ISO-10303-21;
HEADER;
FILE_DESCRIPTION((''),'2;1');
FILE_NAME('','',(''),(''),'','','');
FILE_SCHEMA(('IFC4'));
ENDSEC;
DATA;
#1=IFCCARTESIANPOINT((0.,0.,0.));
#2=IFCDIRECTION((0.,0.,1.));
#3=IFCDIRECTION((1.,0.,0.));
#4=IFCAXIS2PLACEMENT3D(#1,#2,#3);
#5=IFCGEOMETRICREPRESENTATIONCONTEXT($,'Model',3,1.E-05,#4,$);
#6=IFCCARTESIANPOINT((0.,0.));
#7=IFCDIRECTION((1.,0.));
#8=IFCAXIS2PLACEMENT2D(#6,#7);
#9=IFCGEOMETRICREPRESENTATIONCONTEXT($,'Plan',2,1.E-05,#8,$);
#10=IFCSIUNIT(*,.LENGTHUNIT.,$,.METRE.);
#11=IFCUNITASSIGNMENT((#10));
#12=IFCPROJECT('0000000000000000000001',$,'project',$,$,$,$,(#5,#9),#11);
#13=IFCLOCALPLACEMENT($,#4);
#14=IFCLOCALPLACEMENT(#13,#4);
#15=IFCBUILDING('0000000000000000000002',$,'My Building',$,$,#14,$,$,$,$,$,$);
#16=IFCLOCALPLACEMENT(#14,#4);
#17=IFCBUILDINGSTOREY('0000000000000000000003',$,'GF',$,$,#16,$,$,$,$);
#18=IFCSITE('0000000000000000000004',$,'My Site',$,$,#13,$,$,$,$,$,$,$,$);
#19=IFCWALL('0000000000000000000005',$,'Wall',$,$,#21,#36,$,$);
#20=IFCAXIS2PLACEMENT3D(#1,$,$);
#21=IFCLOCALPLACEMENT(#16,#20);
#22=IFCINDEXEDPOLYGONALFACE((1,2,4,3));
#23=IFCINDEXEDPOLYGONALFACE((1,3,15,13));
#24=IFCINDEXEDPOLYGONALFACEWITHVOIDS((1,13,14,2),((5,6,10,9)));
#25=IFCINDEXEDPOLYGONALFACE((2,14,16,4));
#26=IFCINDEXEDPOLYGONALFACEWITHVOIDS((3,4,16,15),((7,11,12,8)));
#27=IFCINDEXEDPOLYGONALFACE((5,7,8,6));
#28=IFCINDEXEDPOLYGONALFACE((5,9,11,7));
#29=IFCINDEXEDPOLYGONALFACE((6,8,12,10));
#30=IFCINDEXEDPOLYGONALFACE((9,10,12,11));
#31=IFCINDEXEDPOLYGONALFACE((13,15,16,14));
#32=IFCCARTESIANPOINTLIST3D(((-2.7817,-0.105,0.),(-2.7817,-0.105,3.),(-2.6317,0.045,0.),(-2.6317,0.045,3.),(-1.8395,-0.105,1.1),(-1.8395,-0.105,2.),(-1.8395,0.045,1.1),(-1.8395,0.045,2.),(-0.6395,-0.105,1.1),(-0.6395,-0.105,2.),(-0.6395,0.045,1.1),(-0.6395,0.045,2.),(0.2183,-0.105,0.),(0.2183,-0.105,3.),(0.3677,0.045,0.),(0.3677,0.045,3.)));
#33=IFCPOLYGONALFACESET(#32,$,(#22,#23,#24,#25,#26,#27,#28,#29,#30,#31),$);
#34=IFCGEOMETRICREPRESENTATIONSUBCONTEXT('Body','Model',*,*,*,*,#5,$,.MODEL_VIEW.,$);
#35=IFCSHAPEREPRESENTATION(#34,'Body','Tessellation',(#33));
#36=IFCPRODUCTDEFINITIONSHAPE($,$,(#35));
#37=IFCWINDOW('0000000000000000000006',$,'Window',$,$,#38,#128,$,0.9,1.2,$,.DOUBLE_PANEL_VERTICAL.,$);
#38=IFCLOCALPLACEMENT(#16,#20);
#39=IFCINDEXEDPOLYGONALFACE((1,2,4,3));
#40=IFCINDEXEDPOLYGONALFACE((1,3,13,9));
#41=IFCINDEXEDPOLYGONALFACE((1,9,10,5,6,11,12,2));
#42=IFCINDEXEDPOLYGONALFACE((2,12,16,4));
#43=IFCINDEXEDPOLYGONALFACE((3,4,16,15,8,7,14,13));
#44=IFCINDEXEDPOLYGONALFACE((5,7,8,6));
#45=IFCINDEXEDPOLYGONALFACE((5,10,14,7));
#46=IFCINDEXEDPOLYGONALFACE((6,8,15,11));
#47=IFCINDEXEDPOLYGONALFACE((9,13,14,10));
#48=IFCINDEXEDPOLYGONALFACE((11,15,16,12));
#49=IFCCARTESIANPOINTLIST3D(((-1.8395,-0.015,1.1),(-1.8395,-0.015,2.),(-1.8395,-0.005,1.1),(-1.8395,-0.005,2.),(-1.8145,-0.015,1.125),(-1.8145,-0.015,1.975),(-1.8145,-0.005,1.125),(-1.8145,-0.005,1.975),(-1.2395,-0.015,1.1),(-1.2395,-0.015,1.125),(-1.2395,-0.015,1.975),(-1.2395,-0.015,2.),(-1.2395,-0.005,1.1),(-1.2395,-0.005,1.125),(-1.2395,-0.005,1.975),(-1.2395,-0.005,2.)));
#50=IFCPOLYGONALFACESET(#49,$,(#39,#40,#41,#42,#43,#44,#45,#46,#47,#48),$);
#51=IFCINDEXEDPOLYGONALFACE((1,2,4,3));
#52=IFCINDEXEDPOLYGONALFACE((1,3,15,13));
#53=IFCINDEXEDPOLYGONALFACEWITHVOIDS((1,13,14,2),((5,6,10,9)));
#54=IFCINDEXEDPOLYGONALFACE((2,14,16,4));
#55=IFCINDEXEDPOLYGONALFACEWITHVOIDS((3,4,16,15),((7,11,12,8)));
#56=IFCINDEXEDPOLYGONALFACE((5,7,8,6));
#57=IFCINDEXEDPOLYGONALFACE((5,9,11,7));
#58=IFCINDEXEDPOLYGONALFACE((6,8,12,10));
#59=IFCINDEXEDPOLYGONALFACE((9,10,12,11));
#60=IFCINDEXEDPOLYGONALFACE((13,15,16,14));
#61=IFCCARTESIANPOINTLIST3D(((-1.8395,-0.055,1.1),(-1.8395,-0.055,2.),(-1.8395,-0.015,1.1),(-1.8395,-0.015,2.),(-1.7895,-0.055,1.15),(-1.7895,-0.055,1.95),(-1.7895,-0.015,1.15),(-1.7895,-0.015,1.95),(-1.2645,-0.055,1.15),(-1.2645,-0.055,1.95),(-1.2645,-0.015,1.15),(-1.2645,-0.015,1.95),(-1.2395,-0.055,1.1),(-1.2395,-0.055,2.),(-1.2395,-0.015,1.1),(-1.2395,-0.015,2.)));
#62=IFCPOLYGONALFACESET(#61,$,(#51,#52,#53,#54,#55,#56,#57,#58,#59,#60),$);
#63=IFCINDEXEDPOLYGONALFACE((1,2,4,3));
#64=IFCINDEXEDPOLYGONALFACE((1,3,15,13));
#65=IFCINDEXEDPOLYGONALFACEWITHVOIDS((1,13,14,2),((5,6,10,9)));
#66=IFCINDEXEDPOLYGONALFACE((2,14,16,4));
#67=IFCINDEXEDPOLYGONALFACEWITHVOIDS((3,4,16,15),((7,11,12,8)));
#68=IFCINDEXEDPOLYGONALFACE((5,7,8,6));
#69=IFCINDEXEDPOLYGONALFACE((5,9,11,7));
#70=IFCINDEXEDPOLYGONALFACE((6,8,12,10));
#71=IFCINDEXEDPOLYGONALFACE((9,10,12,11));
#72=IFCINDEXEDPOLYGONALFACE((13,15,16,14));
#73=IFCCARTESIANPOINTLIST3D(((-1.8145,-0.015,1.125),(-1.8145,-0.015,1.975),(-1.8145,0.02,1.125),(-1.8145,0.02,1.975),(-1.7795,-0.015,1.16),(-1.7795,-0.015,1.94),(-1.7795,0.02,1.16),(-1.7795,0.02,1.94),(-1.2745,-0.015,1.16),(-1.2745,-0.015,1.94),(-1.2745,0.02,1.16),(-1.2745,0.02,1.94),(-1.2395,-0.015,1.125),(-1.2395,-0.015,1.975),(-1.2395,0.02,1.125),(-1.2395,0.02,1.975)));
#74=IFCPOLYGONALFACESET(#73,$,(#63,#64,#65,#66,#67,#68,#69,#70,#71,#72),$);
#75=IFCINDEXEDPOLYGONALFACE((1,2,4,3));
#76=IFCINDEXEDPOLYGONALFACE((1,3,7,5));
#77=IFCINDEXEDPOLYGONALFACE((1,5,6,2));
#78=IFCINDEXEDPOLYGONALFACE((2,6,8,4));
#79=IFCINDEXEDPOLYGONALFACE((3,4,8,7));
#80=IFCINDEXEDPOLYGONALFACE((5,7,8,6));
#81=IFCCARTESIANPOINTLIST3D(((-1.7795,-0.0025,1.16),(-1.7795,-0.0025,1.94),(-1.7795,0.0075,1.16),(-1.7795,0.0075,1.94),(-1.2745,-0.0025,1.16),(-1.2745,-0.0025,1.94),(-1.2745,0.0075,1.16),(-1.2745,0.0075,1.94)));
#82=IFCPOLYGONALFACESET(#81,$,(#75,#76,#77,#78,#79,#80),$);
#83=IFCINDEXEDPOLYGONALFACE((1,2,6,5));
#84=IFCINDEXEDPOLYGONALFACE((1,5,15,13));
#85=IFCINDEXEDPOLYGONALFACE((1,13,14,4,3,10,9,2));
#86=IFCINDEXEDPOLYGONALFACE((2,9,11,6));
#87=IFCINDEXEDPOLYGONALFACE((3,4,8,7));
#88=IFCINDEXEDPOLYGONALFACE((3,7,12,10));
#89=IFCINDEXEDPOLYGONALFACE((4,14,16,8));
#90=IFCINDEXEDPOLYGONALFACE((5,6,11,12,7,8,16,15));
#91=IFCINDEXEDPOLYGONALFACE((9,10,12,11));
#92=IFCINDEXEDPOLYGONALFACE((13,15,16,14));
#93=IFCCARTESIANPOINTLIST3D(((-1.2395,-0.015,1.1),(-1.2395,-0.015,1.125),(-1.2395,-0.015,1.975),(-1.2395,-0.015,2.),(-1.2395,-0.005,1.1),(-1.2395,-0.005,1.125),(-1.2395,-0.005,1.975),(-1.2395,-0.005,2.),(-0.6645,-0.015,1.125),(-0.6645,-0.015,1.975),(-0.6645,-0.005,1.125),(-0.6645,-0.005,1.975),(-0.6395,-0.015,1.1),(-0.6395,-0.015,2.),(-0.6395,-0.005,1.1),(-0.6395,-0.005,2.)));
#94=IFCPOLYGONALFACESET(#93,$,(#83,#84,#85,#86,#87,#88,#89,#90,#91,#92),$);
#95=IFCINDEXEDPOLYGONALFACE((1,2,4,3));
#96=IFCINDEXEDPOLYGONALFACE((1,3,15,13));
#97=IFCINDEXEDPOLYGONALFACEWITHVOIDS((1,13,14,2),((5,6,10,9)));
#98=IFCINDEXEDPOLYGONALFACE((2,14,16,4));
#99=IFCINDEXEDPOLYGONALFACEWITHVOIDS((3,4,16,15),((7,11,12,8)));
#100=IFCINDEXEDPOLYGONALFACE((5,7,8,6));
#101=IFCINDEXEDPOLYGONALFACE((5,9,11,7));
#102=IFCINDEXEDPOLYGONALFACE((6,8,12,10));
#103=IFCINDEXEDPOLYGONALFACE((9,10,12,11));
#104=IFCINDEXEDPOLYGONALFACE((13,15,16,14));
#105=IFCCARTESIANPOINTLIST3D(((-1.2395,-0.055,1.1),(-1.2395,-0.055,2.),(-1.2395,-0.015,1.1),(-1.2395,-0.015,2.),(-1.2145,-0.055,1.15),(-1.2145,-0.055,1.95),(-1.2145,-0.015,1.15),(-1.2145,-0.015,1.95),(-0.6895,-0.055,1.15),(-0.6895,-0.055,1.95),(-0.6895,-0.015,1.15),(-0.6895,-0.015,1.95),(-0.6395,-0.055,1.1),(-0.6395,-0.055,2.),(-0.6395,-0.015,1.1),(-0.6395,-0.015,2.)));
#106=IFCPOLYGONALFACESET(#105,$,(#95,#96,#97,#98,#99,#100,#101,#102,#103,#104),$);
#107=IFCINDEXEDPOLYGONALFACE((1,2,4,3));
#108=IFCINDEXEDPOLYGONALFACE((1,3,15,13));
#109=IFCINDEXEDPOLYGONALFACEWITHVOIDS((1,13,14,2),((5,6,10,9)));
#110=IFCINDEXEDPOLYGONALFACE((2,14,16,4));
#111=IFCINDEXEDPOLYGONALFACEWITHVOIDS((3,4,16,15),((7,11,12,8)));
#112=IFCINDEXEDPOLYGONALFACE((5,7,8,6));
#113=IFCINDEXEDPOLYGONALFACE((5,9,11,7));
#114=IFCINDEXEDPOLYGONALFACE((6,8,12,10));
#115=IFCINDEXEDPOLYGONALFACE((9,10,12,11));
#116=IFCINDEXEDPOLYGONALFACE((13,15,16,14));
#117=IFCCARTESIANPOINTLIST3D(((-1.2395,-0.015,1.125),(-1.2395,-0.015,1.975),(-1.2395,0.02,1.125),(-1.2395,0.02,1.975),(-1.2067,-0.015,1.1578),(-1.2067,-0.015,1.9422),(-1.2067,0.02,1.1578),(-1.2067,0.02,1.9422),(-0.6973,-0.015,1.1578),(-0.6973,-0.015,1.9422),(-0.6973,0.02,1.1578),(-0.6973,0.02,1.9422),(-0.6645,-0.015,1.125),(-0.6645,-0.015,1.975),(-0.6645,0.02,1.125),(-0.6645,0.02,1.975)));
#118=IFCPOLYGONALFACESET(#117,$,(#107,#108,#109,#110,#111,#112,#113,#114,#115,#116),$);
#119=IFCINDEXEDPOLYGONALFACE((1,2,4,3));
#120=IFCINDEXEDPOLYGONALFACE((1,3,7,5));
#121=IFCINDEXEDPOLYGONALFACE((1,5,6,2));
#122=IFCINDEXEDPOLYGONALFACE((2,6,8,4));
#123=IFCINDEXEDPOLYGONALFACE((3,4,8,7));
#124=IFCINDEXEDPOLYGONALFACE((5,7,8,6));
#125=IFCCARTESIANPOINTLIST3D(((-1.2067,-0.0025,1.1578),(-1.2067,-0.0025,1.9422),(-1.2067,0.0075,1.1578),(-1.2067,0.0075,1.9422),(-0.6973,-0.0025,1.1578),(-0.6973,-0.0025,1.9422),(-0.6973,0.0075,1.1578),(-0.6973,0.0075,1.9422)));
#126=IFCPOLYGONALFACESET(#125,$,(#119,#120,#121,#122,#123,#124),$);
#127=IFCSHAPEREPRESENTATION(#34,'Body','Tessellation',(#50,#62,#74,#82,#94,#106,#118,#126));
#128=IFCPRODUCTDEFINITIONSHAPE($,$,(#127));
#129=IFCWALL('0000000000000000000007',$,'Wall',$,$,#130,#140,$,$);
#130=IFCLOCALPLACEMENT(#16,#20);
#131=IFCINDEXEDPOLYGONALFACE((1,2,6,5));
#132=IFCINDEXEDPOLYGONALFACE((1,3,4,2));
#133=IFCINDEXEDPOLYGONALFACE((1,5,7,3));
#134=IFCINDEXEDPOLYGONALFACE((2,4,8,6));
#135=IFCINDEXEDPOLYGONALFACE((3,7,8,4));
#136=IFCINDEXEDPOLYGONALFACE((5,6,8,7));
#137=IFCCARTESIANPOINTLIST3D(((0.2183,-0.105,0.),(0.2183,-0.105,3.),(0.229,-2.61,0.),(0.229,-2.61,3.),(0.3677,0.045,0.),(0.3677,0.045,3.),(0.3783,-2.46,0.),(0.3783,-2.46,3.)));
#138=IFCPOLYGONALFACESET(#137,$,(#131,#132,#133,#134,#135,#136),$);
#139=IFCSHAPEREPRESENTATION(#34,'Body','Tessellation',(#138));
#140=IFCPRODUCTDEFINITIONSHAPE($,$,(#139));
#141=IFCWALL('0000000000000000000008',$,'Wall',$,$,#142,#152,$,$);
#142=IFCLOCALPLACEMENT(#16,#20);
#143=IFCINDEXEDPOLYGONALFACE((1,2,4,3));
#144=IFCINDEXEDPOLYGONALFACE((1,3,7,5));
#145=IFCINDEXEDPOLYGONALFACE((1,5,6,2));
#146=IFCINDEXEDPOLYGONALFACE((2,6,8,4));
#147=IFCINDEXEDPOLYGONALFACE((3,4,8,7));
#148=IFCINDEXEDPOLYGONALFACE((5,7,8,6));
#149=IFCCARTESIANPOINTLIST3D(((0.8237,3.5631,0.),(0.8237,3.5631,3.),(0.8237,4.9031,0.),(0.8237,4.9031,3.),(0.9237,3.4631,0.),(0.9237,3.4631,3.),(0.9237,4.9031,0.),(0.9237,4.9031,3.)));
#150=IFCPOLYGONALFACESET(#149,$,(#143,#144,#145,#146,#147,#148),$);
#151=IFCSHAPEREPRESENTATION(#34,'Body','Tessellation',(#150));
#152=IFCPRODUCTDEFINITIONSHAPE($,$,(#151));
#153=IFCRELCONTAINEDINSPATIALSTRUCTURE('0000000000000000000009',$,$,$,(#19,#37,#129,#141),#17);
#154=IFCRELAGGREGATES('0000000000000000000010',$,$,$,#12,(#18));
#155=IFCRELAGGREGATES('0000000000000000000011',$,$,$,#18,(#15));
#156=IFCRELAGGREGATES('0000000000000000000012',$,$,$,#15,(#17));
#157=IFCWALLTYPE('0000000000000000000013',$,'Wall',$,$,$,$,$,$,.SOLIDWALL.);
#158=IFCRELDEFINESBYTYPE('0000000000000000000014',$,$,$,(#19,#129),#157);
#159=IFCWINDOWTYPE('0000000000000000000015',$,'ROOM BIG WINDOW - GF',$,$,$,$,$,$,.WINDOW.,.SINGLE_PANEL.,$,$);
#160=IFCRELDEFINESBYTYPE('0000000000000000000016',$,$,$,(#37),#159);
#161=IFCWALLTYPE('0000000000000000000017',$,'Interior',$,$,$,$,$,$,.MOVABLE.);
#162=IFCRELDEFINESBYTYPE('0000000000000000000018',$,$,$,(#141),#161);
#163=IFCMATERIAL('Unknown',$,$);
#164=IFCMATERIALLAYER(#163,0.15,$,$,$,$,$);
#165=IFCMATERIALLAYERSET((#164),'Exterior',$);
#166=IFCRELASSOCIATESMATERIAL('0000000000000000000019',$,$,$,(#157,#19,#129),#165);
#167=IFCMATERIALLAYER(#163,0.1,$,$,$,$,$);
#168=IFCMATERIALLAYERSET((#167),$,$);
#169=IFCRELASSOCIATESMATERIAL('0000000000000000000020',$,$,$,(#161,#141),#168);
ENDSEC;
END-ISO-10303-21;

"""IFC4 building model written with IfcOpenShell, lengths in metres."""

from ifc_helpers import new_model, entity, si_unit, frame, origin_with_axes, origin_2d_with_axis, place, context, subcontext, project, spatial, line, indexed_curve, outline, extrude, shape, source, transform, mapped, material, layer, layer_set, layer_usage, type_object, type_shapes, element, fill, save


model = new_model("IFC4")

# Units and contexts
model_context = context("Model", 3, precision=1e-05, world=origin_with_axes())
plan_context = context("Plan", 2, precision=1e-05, world=origin_2d_with_axis())
body_context_1 = subcontext(model_context, "Body", "Model", "MODEL_VIEW")
body_context_2 = subcontext(plan_context, "Body", "Plan", "PLAN_VIEW")
ifc_project = project(units=[si_unit("LENGTHUNIT", "METRE")], contexts=[model_context, plan_context])

# Site, building, storey
site_placement = place(None, origin_with_axes())
site = spatial("IfcSite", under=ifc_project, at=site_placement, Name="My Site")
building_placement = place(site_placement, origin_with_axes())
building = spatial("IfcBuilding", under=site, at=building_placement, Name="My Building")
storey_placement = place(building_placement, origin_with_axes())
storey = spatial("IfcBuildingStorey", under=building, at=storey_placement, Name="GF")

# Shared definitions
ifc_material = material(Name="Unknown")

# Shared definitions
ifc_layer_1 = layer(ifc_material, 0.15)
ifc_layer_set_1 = layer_set([ifc_layer_1], Name="Exterior")
wall_type_1 = type_object("IfcWallType", Name="Wall", PredefinedType="SOLIDWALL", material=ifc_layer_set_1)

# Wall, opening, window
shared_shape_1 = source(origin_with_axes(), body_context_1, "Body", "SweptSolid", [
    extrude(outline(indexed_curve([(0.0, 0.0), (1.2, 0.0), (1.2, 0.9), (0.0, 0.9)], segments=[line(1, 2, 3, 4, 1)])), frame((0.0, -0.6, 0.0), z_axis=(0.0, -1.0, 0.0), x_axis=(1.0, 0.0, 0.0)), (0.0, 0.0, -1.0), 1.2),
])
window_type_1 = type_object("IfcWindowType", Name="ROOM BIG WINDOW - GF", PartitioningType="SINGLE_PANEL", PredefinedType="WINDOW")
shared_shape_2 = source(origin_with_axes(), body_context_1, "Body", "SweptSolid", [
    extrude(outline(indexed_curve([(0.6, 0.0), (0.0, 0.0), (0.0, 0.9), (0.6, 0.9), (0.6, 0.875), (0.025, 0.875), (0.025, 0.025), (0.6, 0.025)], segments=[line(1, 2, 3, 4, 5, 6, 7, 8, 1)])), frame((0.0, 0.09, 0.0), z_axis=(0.0, -1.0, 0.0), x_axis=(1.0, 0.0, 0.0)), (0.0, 0.0, -1.0), 0.01),
    extrude(outline(indexed_curve([(0.0, 0.0), (0.6, 0.0), (0.6, 0.9), (0.0, 0.9)], segments=[line(1, 2, 3, 4, 1)]), holes=[indexed_curve([(0.05, 0.05), (0.575, 0.05), (0.575, 0.85), (0.05, 0.85)], segments=[line(1, 2, 3, 4, 1)])]), frame((0.0, 0.05, 0.0), z_axis=(0.0, -1.0, 0.0), x_axis=(1.0, 0.0, 0.0)), (0.0, 0.0, -1.0), 0.04),
    extrude(outline(indexed_curve([(0.0, 0.0), (0.575, 0.0), (0.575, 0.85), (0.0, 0.85)], segments=[line(1, 2, 3, 4, 1)]), holes=[indexed_curve([(0.035, 0.035), (0.54, 0.035), (0.54, 0.815), (0.035, 0.815)], segments=[line(1, 2, 3, 4, 1)])]), frame((0.025, 0.09, 0.025), z_axis=(0.0, -1.0, 0.0), x_axis=(1.0, 0.0, 0.0)), (0.0, 0.0, -1.0), 0.035),
    extrude(outline(indexed_curve([(0.035, 0.035), (0.54, 0.035), (0.54, 0.815), (0.035, 0.815)], segments=[line(1, 2, 3, 4, 1)])), frame((0.025, 0.1025, 0.025), z_axis=(0.0, -1.0, 0.0), x_axis=(1.0, 0.0, 0.0)), (0.0, 0.0, -1.0), 0.01),
    extrude(outline(indexed_curve([(0.0, 0.9), (0.6, 0.9), (0.6, 0.0), (0.0, 0.0), (0.0, 0.025), (0.575, 0.025), (0.575, 0.875), (0.0, 0.875)], segments=[line(1, 2, 3, 4, 5, 6, 7, 8, 1)])), frame((0.6, 0.09, 0.0), z_axis=(0.0, -1.0, 0.0), x_axis=(1.0, 0.0, 0.0)), (0.0, 0.0, -1.0), 0.01),
    extrude(outline(indexed_curve([(0.0, 0.0), (0.6, 0.0), (0.6, 0.9), (0.0, 0.9)], segments=[line(1, 2, 3, 4, 1)]), holes=[indexed_curve([(0.025, 0.05), (0.55, 0.05), (0.55, 0.85), (0.025, 0.85)], segments=[line(1, 2, 3, 4, 1)])]), frame((0.6, 0.05, 0.0), z_axis=(0.0, -1.0, 0.0), x_axis=(1.0, 0.0, 0.0)), (0.0, 0.0, -1.0), 0.04),
    extrude(outline(indexed_curve([(0.0, 0.0), (0.575, 0.0), (0.575, 0.85), (0.0, 0.85)], segments=[line(1, 2, 3, 4, 1)]), holes=[indexed_curve([(0.0328, 0.0328), (0.5422, 0.0328), (0.5422, 0.8172), (0.0328, 0.8172)], segments=[line(1, 2, 3, 4, 1)])]), frame((0.6, 0.09, 0.025), z_axis=(0.0, -1.0, 0.0), x_axis=(1.0, 0.0, 0.0)), (0.0, 0.0, -1.0), 0.035),
    extrude(outline(indexed_curve([(0.0328, 0.0328), (0.5422, 0.0328), (0.5422, 0.8172), (0.0328, 0.8172)], segments=[line(1, 2, 3, 4, 1)])), frame((0.6, 0.1025, 0.025), z_axis=(0.0, -1.0, 0.0), x_axis=(1.0, 0.0, 0.0)), (0.0, 0.0, -1.0), 0.01),
])
shared_shape_3 = source(origin_with_axes(), body_context_2, "Body", "Curve2D", [
    entity("IfcIndexedPolyCurve", entity("IfcCartesianPointList2D", [[0.05, 0.05], [0.575, 0.05]])),
    entity("IfcIndexedPolyCurve", entity("IfcCartesianPointList2D", [[0.0, 0.1], [0.025, 0.1], [0.025, 0.09], [0.05, 0.09], [0.05, 0.05], [0.0, 0.05]]), [entity("IfcLineIndex", [1, 2, 3, 4, 5, 6, 1])]),
    entity("IfcIndexedPolyCurve", entity("IfcCartesianPointList2D", [[0.6, 0.1], [0.6, 0.1], [0.6, 0.09], [0.575, 0.09], [0.575, 0.05], [0.6, 0.05]])),
    entity("IfcIndexedPolyCurve", entity("IfcCartesianPointList2D", [[0.025, 0.09], [0.06, 0.09], [0.06, 0.125], [0.025, 0.125]]), [entity("IfcLineIndex", [1, 2, 3, 4, 1])]),
    entity("IfcIndexedPolyCurve", entity("IfcCartesianPointList2D", [[0.6, 0.09], [0.565, 0.09], [0.565, 0.125], [0.6, 0.125]]), [entity("IfcLineIndex", [1, 2, 3, 4, 1])]),
    entity("IfcIndexedPolyCurve", entity("IfcCartesianPointList2D", [[0.06, 0.09], [0.565, 0.09]])),
    entity("IfcIndexedPolyCurve", entity("IfcCartesianPointList2D", [[0.06, 0.125], [0.565, 0.125]])),
    entity("IfcIndexedPolyCurve", entity("IfcCartesianPointList2D", [[0.06, 0.1075], [0.565, 0.1075]])),
    entity("IfcIndexedPolyCurve", entity("IfcCartesianPointList2D", [[0.625, 0.05], [1.15, 0.05]])),
    entity("IfcIndexedPolyCurve", entity("IfcCartesianPointList2D", [[0.6, 0.1], [0.6, 0.1], [0.6, 0.09], [0.625, 0.09], [0.625, 0.05], [0.6, 0.05]])),
    entity("IfcIndexedPolyCurve", entity("IfcCartesianPointList2D", [[1.2, 0.1], [1.175, 0.1], [1.175, 0.09], [1.15, 0.09], [1.15, 0.05], [1.2, 0.05]]), [entity("IfcLineIndex", [1, 2, 3, 4, 5, 6, 1])]),
    entity("IfcIndexedPolyCurve", entity("IfcCartesianPointList2D", [[0.6, 0.09], [0.6328, 0.09], [0.6328, 0.125], [0.6, 0.125]]), [entity("IfcLineIndex", [1, 2, 3, 4, 1])]),
    entity("IfcIndexedPolyCurve", entity("IfcCartesianPointList2D", [[1.175, 0.09], [1.1422, 0.09], [1.1422, 0.125], [1.175, 0.125]]), [entity("IfcLineIndex", [1, 2, 3, 4, 1])]),
    entity("IfcIndexedPolyCurve", entity("IfcCartesianPointList2D", [[0.6328, 0.09], [1.1422, 0.09]])),
    entity("IfcIndexedPolyCurve", entity("IfcCartesianPointList2D", [[0.6328, 0.125], [1.1422, 0.125]])),
    entity("IfcIndexedPolyCurve", entity("IfcCartesianPointList2D", [[0.6328, 0.1075], [1.1422, 0.1075]])),
])
type_shapes(window_type_1, [shared_shape_2, shared_shape_3])
ifc_layer_usage_1 = layer_usage(ifc_layer_set_1, "AXIS2", "POSITIVE", 0.0)
wall_1_placement = place(storey_placement, frame((-2.7817, -0.105, 0.0), z_axis=(0.0, 0.0, 1.0), x_axis=(1.0, 0.0, 0.0)))
wall_1 = element("IfcWall", 1, at=wall_1_placement, inside=storey, type_object=wall_type_1, material=ifc_layer_usage_1, Name="Wall", context=body_context_1, shape_type="SweptSolid", body=[
    extrude(outline(indexed_curve([(0.0, 0.0), (0.15, 0.15), (3.1494, 0.15), (3.0, 0.0)], segments=[line(1, 2, 3, 4, 1)])), origin_with_axes(), (0.0, 0.0, 1.0), 3.0),
])
opening_1_placement = place(wall_1_placement, frame((0.9421, 0.0, 1.1), z_axis=(0.0, 0.0, 1.0), x_axis=(1.0, 0.0, 0.0)))
opening_1 = element("IfcOpeningElement", 2, at=opening_1_placement, cuts=wall_1, PredefinedType="OPENING", context=body_context_1, shape_type="MappedRepresentation", body=[
    mapped(shared_shape_1, transform((0.0, 0.0, 0.0), x_axis=(1.0, 0.0, 0.0), y_axis=(0.0, 1.0, 0.0), z_axis=(0.0, 0.0, 1.0), scale=1.0)),
])
window_1_placement = place(opening_1_placement, frame((0.0, 0.0, 0.0), z_axis=(0.0, 0.0, 1.0), x_axis=(1.0, 0.0, 0.0)))
window_1 = element("IfcWindow", 3, at=window_1_placement, inside=storey, type_object=window_type_1, Name="Window", OverallHeight=0.9, OverallWidth=1.2, PartitioningType="DOUBLE_PANEL_VERTICAL", shapes=[
    shape(body_context_1, "Body", "MappedRepresentation", [mapped(shared_shape_2, transform((0.0, 0.0, 0.0), x_axis=(1.0, 0.0, 0.0), y_axis=(0.0, 1.0, 0.0), z_axis=(0.0, 0.0, 1.0), scale=1.0))]),
    shape(body_context_2, "Body", "MappedRepresentation", [mapped(shared_shape_3, transform((0.0, 0.0, 0.0), x_axis=(1.0, 0.0, 0.0), y_axis=(0.0, 1.0, 0.0), z_axis=(0.0, 0.0, 1.0), scale=1.0))]),
])
fill(opening_1, window_1)

# Walls
ifc_layer_usage_2 = layer_usage(ifc_layer_set_1, "AXIS2", "POSITIVE", 0.0)
wall_2_placement = place(storey_placement, frame((0.2183, -0.105, 0.0), z_axis=(0.0, 0.0, 1.0), x_axis=(0.004245, -0.999991, 0.0)))
element("IfcWall", 4, at=wall_2_placement, inside=storey, type_object=wall_type_1, material=ifc_layer_usage_2, Name="Wall", context=body_context_1, shape_type="SweptSolid", body=[
    extrude(outline(indexed_curve([(0.0, 0.0), (-0.1494, 0.15), (2.3557, 0.15), (2.505, 0.0)], segments=[line(1, 2, 3, 4, 1)])), origin_with_axes(), (0.0, 0.0, 1.0), 3.0),
])
ifc_layer_2 = layer(ifc_material, 0.1)
ifc_layer_set_2 = layer_set([ifc_layer_2])
ifc_layer_usage_3 = layer_usage(ifc_layer_set_2, "AXIS2", "POSITIVE", 0.0)
wall_type_2 = type_object("IfcWallType", Name="Interior", PredefinedType="MOVABLE", material=ifc_layer_set_2)
wall_3_placement = place(storey_placement, frame((0.8237, 4.9031, 0.0), z_axis=(0.0, 0.0, 1.0), x_axis=(0.0, -1.0, 0.0)))
element("IfcWall", 5, at=wall_3_placement, inside=storey, type_object=wall_type_2, material=ifc_layer_usage_3, Name="Wall", context=body_context_1, shape_type="SweptSolid", body=[
    extrude(outline(indexed_curve([(0.0, 0.0), (0.0, 0.1), (1.44, 0.1), (1.34, 0.0)], segments=[line(1, 2, 3, 4, 1)])), origin_with_axes(), (0.0, 0.0, 1.0), 3.0),
])

save(model, "model.ifc")
